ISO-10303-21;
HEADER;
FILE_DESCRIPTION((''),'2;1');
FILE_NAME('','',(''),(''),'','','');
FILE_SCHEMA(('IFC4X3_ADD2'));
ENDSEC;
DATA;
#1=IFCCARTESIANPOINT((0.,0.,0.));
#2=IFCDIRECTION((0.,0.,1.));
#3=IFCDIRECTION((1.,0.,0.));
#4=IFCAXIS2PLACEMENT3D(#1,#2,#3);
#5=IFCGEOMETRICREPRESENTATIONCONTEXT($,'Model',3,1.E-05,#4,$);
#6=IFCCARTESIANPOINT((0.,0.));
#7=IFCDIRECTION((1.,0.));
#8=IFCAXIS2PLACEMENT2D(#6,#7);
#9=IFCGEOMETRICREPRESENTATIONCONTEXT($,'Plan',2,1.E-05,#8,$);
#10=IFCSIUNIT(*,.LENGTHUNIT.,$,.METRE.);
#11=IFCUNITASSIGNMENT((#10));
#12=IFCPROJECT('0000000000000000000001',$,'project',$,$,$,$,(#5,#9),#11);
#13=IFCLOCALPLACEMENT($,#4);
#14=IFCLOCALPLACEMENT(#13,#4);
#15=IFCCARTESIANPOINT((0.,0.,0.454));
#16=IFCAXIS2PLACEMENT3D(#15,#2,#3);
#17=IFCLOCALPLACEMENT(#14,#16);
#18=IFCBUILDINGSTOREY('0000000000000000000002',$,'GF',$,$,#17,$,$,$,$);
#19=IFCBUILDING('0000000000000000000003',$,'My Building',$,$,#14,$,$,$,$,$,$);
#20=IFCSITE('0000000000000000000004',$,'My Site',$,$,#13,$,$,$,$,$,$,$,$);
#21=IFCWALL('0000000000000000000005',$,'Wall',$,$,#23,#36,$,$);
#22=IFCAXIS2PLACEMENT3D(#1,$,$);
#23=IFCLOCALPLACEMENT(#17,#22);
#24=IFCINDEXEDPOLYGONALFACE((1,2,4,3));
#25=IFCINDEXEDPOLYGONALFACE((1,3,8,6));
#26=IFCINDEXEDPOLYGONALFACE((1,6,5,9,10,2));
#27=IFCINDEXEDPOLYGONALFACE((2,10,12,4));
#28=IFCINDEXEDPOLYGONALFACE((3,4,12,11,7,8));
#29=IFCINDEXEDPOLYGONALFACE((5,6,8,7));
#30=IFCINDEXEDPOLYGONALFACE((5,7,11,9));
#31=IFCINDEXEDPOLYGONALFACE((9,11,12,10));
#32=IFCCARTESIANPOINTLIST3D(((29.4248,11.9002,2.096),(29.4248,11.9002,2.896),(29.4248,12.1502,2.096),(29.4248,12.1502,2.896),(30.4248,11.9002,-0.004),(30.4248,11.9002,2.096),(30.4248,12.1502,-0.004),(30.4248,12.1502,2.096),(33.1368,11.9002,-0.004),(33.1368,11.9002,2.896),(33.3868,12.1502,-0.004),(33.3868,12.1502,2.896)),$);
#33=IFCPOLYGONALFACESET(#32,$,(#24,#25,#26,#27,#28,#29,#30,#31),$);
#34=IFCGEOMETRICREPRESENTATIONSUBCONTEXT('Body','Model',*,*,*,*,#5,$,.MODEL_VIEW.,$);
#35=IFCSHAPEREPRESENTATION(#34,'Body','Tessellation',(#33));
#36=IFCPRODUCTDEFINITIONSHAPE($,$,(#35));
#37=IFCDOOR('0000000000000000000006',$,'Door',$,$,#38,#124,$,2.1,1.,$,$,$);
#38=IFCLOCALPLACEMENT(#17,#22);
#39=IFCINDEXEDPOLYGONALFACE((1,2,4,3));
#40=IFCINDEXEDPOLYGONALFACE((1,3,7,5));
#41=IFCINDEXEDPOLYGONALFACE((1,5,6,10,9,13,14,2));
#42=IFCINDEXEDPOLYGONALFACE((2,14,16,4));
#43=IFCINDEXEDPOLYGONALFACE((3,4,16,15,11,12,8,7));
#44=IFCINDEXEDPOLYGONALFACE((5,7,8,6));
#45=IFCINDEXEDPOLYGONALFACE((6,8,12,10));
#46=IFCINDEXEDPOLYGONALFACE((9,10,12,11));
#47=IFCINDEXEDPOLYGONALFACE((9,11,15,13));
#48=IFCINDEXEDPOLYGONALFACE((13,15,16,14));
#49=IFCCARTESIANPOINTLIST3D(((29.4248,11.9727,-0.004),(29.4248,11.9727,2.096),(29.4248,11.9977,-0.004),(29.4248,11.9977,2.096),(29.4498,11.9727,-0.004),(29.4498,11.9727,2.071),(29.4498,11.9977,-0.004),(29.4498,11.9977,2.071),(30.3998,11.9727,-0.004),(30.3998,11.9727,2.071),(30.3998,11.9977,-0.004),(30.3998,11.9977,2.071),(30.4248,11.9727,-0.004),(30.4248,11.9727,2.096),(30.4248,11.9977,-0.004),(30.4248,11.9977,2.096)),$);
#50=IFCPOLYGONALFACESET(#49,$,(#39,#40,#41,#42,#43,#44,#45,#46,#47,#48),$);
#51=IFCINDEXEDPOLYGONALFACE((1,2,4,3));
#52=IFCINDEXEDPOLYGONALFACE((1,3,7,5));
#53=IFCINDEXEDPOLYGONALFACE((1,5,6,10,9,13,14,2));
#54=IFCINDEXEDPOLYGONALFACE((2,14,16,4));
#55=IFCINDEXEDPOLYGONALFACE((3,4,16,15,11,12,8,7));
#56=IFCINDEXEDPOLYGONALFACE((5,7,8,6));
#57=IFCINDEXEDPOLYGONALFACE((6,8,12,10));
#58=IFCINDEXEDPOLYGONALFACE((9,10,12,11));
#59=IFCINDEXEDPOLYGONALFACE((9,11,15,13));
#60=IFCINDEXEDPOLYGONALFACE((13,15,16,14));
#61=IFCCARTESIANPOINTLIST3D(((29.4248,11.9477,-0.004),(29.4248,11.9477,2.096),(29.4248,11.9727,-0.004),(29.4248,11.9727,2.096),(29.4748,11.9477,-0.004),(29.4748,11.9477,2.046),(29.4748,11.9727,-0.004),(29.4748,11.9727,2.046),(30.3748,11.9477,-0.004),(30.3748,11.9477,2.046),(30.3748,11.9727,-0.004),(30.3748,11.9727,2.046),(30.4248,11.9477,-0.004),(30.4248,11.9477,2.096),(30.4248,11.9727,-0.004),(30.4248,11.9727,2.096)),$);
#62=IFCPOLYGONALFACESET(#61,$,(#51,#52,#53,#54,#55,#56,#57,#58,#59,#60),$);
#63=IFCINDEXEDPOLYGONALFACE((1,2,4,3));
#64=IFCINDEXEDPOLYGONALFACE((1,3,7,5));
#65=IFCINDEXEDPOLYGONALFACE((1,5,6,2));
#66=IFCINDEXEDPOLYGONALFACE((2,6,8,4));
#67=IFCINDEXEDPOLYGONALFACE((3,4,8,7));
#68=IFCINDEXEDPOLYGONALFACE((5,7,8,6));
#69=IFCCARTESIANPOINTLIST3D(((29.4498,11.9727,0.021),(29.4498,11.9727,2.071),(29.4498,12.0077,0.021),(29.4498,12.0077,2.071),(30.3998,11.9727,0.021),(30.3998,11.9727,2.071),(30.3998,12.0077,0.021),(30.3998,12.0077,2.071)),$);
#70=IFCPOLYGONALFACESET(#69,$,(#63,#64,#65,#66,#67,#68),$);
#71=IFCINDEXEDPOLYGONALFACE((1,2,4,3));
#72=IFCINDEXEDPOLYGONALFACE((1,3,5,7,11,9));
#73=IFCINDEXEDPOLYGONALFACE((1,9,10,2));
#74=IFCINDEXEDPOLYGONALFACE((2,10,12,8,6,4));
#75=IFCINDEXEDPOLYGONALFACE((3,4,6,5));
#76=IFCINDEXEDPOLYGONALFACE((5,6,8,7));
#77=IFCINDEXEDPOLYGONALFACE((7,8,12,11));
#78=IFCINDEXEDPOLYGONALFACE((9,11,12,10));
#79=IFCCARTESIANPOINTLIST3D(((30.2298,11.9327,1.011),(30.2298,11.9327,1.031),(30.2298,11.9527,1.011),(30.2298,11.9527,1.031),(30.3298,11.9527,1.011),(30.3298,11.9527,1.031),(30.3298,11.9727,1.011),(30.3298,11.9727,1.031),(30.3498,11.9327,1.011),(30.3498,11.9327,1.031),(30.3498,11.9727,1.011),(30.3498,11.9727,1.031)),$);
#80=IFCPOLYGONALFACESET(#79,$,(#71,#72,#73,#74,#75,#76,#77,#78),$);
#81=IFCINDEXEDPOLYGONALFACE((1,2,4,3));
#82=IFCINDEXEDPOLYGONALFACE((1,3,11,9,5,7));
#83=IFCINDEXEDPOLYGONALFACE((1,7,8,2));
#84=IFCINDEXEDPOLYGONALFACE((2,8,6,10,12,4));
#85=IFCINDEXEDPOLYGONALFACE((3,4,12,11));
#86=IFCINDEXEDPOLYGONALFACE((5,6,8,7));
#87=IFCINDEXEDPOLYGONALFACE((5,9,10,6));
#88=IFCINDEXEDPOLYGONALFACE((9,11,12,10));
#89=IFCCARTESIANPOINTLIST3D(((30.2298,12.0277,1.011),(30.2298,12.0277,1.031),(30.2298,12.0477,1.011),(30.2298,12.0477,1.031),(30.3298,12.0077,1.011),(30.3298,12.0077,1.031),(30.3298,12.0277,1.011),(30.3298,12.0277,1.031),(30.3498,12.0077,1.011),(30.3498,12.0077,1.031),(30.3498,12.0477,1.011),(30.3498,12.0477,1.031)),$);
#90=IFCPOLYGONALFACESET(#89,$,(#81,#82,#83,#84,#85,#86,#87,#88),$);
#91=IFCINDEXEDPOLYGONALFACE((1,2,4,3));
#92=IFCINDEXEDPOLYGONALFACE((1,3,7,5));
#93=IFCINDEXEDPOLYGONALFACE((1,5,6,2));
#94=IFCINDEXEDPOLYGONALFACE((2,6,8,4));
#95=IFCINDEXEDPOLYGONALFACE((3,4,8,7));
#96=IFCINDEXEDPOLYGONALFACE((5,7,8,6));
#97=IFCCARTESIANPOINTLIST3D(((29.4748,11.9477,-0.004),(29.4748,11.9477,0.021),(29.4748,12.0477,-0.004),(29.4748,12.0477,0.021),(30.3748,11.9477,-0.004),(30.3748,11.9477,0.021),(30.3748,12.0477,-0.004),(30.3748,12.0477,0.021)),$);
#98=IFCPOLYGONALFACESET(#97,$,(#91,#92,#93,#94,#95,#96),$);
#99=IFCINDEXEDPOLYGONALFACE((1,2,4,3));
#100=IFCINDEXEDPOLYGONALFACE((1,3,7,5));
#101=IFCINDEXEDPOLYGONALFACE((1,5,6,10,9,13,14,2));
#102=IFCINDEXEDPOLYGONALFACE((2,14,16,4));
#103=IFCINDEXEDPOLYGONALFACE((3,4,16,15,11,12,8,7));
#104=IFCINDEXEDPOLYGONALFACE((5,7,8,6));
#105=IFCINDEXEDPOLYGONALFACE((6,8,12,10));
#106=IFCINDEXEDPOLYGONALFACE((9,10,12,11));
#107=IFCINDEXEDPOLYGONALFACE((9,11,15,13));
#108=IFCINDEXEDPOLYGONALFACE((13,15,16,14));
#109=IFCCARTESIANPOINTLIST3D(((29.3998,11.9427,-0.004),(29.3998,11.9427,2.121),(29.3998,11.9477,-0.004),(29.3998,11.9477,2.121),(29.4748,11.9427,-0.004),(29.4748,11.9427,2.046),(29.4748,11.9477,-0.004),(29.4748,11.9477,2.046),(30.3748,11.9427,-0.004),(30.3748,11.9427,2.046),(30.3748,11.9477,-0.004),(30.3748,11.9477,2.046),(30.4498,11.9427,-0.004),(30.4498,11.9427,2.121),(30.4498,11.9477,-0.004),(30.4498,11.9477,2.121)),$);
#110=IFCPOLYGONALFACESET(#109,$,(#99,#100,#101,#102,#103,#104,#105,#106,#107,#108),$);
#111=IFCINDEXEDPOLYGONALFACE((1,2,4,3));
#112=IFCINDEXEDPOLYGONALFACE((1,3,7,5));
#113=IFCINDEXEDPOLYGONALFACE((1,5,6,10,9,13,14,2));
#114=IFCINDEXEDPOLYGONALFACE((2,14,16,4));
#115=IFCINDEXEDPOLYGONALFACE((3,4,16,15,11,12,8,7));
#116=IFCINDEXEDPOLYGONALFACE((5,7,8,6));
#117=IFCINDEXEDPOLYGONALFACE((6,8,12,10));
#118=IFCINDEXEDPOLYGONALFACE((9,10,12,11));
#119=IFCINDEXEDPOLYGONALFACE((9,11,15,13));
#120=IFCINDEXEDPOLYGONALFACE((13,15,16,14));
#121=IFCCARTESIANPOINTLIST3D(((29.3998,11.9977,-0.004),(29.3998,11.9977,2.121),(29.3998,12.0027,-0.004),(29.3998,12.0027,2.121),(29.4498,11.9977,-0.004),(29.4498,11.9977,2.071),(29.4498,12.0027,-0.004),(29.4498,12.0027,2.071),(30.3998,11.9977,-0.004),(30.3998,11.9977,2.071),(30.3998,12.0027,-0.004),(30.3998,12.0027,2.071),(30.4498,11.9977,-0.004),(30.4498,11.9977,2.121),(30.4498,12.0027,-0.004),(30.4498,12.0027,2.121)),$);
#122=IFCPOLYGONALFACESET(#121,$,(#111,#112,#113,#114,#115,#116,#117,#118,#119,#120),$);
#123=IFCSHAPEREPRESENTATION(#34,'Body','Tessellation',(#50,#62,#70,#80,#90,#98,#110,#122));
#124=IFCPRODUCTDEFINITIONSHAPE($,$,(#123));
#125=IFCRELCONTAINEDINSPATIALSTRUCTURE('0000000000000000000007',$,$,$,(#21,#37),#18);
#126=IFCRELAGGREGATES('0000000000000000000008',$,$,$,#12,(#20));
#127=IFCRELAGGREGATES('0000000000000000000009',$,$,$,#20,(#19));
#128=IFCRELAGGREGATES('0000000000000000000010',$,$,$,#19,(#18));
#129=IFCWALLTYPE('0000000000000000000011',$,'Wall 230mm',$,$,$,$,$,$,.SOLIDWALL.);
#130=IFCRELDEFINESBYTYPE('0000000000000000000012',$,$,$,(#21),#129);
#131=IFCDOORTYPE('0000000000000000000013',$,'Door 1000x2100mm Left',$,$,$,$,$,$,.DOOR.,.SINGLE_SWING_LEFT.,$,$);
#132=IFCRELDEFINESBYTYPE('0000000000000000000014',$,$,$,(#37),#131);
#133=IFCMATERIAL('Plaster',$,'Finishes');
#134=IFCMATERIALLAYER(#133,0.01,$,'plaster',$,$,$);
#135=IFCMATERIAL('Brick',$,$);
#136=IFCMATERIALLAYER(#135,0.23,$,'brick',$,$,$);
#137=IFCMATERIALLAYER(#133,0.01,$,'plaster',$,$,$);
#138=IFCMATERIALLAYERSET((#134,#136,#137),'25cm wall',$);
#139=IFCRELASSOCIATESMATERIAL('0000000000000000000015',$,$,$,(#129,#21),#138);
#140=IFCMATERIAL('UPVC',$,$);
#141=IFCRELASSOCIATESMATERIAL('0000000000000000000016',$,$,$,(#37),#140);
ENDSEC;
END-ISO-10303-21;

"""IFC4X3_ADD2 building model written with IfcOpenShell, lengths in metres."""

from ifc_helpers import new_model, entity, si_unit, frame, origin_with_axes, origin_2d_with_axis, place, context, subcontext, project, spatial, line, indexed_curve, outline, extrude, shape, source, transform, mapped, material, layer, layer_set, layer_usage, type_object, type_shapes, element, fill, save


model = new_model("IFC4X3_ADD2")

# Units and contexts
model_context = context("Model", 3, precision=1e-05, world=origin_with_axes())
plan_context = context("Plan", 2, precision=1e-05, world=origin_2d_with_axis())
body_context_1 = subcontext(model_context, "Body", "Model", "MODEL_VIEW")
body_context_2 = subcontext(plan_context, "Body", "Plan", "PLAN_VIEW")
ifc_project = project(units=[si_unit("LENGTHUNIT", "METRE")], contexts=[model_context, plan_context])

# Site, building, storey
site_placement = place(None, origin_with_axes())
site = spatial("IfcSite", under=ifc_project, at=site_placement, Name="My Site")
building_placement = place(site_placement, origin_with_axes())
building = spatial("IfcBuilding", under=site, at=building_placement, Name="My Building")
storey_placement = place(building_placement, frame((0.0, 0.0, 0.454), z_axis=(0.0, 0.0, 1.0), x_axis=(1.0, 0.0, 0.0)))
storey = spatial("IfcBuildingStorey", under=building, at=storey_placement, Name="GF")

# Shared definitions
ifc_material_1 = material(Name="UPVC")

# Shared definitions
ifc_material_2 = material(Name="Plaster", Category="Finishes")
ifc_layer_1 = layer(ifc_material_2, 0.01, Name="plaster")
ifc_material_3 = material(Name="Brick")
ifc_layer_2 = layer(ifc_material_3, 0.23, Name="brick")
ifc_layer_3 = layer(ifc_material_2, 0.01, Name="plaster")
ifc_layer_set_1 = layer_set([ifc_layer_1, ifc_layer_2, ifc_layer_3], Name="25cm wall")
wall_type_1 = type_object("IfcWallType", Name="Wall 230mm", PredefinedType="SOLIDWALL", material=ifc_layer_set_1)

# Wall, opening, door
ifc_layer_usage_1 = layer_usage(ifc_layer_set_1, "AXIS2", "POSITIVE", 0.0)
wall_1_placement = place(storey_placement, frame((33.3868, 12.1502, -0.004), z_axis=(0.0, 0.0, 1.0), x_axis=(-1.0, 0.0, 0.0)))
wall_1 = element("IfcWall", 1, at=wall_1_placement, inside=storey, type_object=wall_type_1, material=ifc_layer_usage_1, Name="Wall", context=body_context_1, shape_type="SweptSolid", body=[
    extrude(outline(indexed_curve([(0.0, 0.0), (0.25, 0.25), (3.962, 0.25), (3.962, 0.0)], segments=[line(1, 2, 3, 4, 1)])), origin_with_axes(), (0.0, 0.0, 1.0), 2.9),
])
shared_shape_1 = source(origin_with_axes(), body_context_1, "Body", "SweptSolid", [
    extrude(outline(indexed_curve([(0.0, 0.0), (1.0, 0.0), (1.0, 2.1), (0.0, 2.1)], segments=[line(1, 2, 3, 4, 1)])), frame((0.0, -0.6, 0.0), z_axis=(0.0, -1.0, 0.0), x_axis=(1.0, 0.0, 0.0)), (0.0, 0.0, -1.0), 1.2),
])
opening_1_placement = place(wall_1_placement, frame((3.962, 0.2024, 0.0), z_axis=(0.0, 0.0, 1.0), x_axis=(-1.0, 0.0, 0.0)))
opening_1 = element("IfcOpeningElement", 2, at=opening_1_placement, cuts=wall_1, PredefinedType="OPENING", context=body_context_1, shape_type="MappedRepresentation", body=[
    mapped(shared_shape_1, transform((0.0, 0.0, 0.0), x_axis=(1.0, 0.0, 0.0), y_axis=(0.0, 1.0, 0.0), z_axis=(0.0, 0.0, 1.0), scale=1.0)),
])
door_type = type_object("IfcDoorType", Name="Door 1000x2100mm Left", OperationType="SINGLE_SWING_LEFT", PredefinedType="DOOR")
shared_shape_2 = source(origin_with_axes(), body_context_1, "Body", "SweptSolid", [
    extrude(outline(indexed_curve([(0.0, 0.0), (0.0, 2.1), (1.0, 2.1), (1.0, 0.0), (0.975, 0.0), (0.975, 2.075), (0.025, 2.075), (0.025, 0.0)], segments=[line(1, 2, 3, 4, 5, 6, 7, 8, 1)])), frame((0.0, 0.025, 0.0), z_axis=(0.0, -1.0, 0.0), x_axis=(1.0, 0.0, 0.0)), (0.0, 0.0, -1.0), 0.025),
    extrude(outline(indexed_curve([(0.0, 0.0), (0.0, 2.1), (1.0, 2.1), (1.0, 0.0), (0.95, 0.0), (0.95, 2.05), (0.05, 2.05), (0.05, 0.0)], segments=[line(1, 2, 3, 4, 5, 6, 7, 8, 1)])), frame((0.0, 0.0, 0.0), z_axis=(0.0, -1.0, 0.0), x_axis=(1.0, 0.0, 0.0)), (0.0, 0.0, -1.0), 0.025),
    extrude(outline(indexed_curve([(0.0, 0.0), (0.95, 0.0), (0.95, 0.035), (0.0, 0.035)], segments=[line(1, 2, 3, 4, 1)])), frame((0.025, 0.025, 0.025), z_axis=(0.0, 0.0, 1.0), x_axis=(1.0, 0.0, 0.0)), (0.0, 0.0, 1.0), 2.05),
    extrude(outline(indexed_curve([(0.0, 0.0), (0.0, -0.04), (-0.12, -0.04), (-0.12, -0.02), (-0.02, -0.02), (-0.02, 0.0)], segments=[line(1, 2, 3, 4, 5, 6, 1)])), frame((0.925, 0.025, 1.015), z_axis=(0.0, 0.0, 1.0), x_axis=(1.0, 0.0, 0.0)), (0.0, 0.0, 1.0), 0.02),
    extrude(outline(indexed_curve([(0.0, 0.0), (0.0, 0.04), (-0.12, 0.04), (-0.12, 0.02), (-0.02, 0.02), (-0.02, 0.0)], segments=[line(1, 2, 3, 4, 5, 6, 1)])), frame((0.925, 0.06, 1.015), z_axis=(0.0, 0.0, 1.0), x_axis=(1.0, 0.0, 0.0)), (0.0, 0.0, 1.0), 0.02),
    extrude(outline(indexed_curve([(0.0, 0.0), (0.9, 0.0), (0.9, 0.1), (0.0, 0.1)], segments=[line(1, 2, 3, 4, 1)])), frame((0.05, 0.0, 0.0), z_axis=(0.0, 0.0, 1.0), x_axis=(1.0, 0.0, 0.0)), (0.0, 0.0, 1.0), 0.025),
    extrude(outline(indexed_curve([(0.0, 0.0), (0.0, 2.125), (1.05, 2.125), (1.05, 0.0), (0.975, 0.0), (0.975, 2.05), (0.075, 2.05), (0.075, 0.0)], segments=[line(1, 2, 3, 4, 5, 6, 7, 8, 1)])), frame((-0.025, -0.005, 0.0), z_axis=(0.0, -1.0, 0.0), x_axis=(1.0, 0.0, 0.0)), (0.0, 0.0, -1.0), 0.005),
    extrude(outline(indexed_curve([(0.0, 0.0), (0.0, 2.125), (1.05, 2.125), (1.05, 0.0), (1.0, 0.0), (1.0, 2.075), (0.05, 2.075), (0.05, 0.0)], segments=[line(1, 2, 3, 4, 5, 6, 7, 8, 1)])), frame((-0.025, 0.05, 0.0), z_axis=(0.0, -1.0, 0.0), x_axis=(1.0, 0.0, 0.0)), (0.0, 0.0, -1.0), 0.005),
])
shared_shape_3 = source(origin_with_axes(), body_context_2, "Body", "Curve2D", [
    entity("IfcIndexedPolyCurve", entity("IfcCartesianPointList2D", [[0.0, 0.0], [0.0, 0.05], [0.025, 0.05], [0.025, 0.025], [0.05, 0.025], [0.05, 0.0]]), [entity("IfcLineIndex", [1, 2, 3, 4, 5, 6, 1])]),
    entity("IfcIndexedPolyCurve", entity("IfcCartesianPointList2D", [[1.0, 0.0], [1.0, 0.05], [0.975, 0.05], [0.975, 0.025], [0.95, 0.025], [0.95, 0.0]]), [entity("IfcLineIndex", [1, 2, 3, 4, 5, 6, 1])]),
    entity("IfcTrimmedCurve", entity("IfcEllipse", entity("IfcAxis2Placement2D", entity("IfcCartesianPoint", [0.06, 0.05]), entity("IfcDirection", [1.0, 0.0])), 0.915, 0.95), [entity("IfcCartesianPoint", [0.975, 0.05])], [entity("IfcCartesianPoint", [0.06, 1.0])], True, "CARTESIAN"),
    entity("IfcIndexedPolyCurve", entity("IfcCartesianPointList2D", [[0.025, 0.05], [0.06, 0.05], [0.06, 1.0], [0.025, 1.0]]), [entity("IfcLineIndex", [1, 2, 3, 4, 1])]),
])
type_shapes(door_type, [shared_shape_2, shared_shape_3])
door_placement = place(opening_1_placement, frame((0.0, 0.0, 0.0), z_axis=(0.0, 0.0, 1.0), x_axis=(1.0, 0.0, 0.0)))
door = element("IfcDoor", 3, at=door_placement, inside=storey, type_object=door_type, material=ifc_material_1, Name="Door", OverallHeight=2.1, OverallWidth=1.0, shapes=[
    shape(body_context_1, "Body", "MappedRepresentation", [mapped(shared_shape_2, transform((0.0, 0.0, 0.0), x_axis=(1.0, 0.0, 0.0), y_axis=(0.0, 1.0, 0.0), z_axis=(0.0, 0.0, 1.0), scale=1.0))]),
    shape(body_context_2, "Body", "MappedRepresentation", [mapped(shared_shape_3, transform((0.0, 0.0, 0.0), x_axis=(1.0, 0.0, 0.0), y_axis=(0.0, 1.0, 0.0), z_axis=(0.0, 0.0, 1.0), scale=1.0))]),
])
fill(opening_1, door)

save(model, "model.ifc")
